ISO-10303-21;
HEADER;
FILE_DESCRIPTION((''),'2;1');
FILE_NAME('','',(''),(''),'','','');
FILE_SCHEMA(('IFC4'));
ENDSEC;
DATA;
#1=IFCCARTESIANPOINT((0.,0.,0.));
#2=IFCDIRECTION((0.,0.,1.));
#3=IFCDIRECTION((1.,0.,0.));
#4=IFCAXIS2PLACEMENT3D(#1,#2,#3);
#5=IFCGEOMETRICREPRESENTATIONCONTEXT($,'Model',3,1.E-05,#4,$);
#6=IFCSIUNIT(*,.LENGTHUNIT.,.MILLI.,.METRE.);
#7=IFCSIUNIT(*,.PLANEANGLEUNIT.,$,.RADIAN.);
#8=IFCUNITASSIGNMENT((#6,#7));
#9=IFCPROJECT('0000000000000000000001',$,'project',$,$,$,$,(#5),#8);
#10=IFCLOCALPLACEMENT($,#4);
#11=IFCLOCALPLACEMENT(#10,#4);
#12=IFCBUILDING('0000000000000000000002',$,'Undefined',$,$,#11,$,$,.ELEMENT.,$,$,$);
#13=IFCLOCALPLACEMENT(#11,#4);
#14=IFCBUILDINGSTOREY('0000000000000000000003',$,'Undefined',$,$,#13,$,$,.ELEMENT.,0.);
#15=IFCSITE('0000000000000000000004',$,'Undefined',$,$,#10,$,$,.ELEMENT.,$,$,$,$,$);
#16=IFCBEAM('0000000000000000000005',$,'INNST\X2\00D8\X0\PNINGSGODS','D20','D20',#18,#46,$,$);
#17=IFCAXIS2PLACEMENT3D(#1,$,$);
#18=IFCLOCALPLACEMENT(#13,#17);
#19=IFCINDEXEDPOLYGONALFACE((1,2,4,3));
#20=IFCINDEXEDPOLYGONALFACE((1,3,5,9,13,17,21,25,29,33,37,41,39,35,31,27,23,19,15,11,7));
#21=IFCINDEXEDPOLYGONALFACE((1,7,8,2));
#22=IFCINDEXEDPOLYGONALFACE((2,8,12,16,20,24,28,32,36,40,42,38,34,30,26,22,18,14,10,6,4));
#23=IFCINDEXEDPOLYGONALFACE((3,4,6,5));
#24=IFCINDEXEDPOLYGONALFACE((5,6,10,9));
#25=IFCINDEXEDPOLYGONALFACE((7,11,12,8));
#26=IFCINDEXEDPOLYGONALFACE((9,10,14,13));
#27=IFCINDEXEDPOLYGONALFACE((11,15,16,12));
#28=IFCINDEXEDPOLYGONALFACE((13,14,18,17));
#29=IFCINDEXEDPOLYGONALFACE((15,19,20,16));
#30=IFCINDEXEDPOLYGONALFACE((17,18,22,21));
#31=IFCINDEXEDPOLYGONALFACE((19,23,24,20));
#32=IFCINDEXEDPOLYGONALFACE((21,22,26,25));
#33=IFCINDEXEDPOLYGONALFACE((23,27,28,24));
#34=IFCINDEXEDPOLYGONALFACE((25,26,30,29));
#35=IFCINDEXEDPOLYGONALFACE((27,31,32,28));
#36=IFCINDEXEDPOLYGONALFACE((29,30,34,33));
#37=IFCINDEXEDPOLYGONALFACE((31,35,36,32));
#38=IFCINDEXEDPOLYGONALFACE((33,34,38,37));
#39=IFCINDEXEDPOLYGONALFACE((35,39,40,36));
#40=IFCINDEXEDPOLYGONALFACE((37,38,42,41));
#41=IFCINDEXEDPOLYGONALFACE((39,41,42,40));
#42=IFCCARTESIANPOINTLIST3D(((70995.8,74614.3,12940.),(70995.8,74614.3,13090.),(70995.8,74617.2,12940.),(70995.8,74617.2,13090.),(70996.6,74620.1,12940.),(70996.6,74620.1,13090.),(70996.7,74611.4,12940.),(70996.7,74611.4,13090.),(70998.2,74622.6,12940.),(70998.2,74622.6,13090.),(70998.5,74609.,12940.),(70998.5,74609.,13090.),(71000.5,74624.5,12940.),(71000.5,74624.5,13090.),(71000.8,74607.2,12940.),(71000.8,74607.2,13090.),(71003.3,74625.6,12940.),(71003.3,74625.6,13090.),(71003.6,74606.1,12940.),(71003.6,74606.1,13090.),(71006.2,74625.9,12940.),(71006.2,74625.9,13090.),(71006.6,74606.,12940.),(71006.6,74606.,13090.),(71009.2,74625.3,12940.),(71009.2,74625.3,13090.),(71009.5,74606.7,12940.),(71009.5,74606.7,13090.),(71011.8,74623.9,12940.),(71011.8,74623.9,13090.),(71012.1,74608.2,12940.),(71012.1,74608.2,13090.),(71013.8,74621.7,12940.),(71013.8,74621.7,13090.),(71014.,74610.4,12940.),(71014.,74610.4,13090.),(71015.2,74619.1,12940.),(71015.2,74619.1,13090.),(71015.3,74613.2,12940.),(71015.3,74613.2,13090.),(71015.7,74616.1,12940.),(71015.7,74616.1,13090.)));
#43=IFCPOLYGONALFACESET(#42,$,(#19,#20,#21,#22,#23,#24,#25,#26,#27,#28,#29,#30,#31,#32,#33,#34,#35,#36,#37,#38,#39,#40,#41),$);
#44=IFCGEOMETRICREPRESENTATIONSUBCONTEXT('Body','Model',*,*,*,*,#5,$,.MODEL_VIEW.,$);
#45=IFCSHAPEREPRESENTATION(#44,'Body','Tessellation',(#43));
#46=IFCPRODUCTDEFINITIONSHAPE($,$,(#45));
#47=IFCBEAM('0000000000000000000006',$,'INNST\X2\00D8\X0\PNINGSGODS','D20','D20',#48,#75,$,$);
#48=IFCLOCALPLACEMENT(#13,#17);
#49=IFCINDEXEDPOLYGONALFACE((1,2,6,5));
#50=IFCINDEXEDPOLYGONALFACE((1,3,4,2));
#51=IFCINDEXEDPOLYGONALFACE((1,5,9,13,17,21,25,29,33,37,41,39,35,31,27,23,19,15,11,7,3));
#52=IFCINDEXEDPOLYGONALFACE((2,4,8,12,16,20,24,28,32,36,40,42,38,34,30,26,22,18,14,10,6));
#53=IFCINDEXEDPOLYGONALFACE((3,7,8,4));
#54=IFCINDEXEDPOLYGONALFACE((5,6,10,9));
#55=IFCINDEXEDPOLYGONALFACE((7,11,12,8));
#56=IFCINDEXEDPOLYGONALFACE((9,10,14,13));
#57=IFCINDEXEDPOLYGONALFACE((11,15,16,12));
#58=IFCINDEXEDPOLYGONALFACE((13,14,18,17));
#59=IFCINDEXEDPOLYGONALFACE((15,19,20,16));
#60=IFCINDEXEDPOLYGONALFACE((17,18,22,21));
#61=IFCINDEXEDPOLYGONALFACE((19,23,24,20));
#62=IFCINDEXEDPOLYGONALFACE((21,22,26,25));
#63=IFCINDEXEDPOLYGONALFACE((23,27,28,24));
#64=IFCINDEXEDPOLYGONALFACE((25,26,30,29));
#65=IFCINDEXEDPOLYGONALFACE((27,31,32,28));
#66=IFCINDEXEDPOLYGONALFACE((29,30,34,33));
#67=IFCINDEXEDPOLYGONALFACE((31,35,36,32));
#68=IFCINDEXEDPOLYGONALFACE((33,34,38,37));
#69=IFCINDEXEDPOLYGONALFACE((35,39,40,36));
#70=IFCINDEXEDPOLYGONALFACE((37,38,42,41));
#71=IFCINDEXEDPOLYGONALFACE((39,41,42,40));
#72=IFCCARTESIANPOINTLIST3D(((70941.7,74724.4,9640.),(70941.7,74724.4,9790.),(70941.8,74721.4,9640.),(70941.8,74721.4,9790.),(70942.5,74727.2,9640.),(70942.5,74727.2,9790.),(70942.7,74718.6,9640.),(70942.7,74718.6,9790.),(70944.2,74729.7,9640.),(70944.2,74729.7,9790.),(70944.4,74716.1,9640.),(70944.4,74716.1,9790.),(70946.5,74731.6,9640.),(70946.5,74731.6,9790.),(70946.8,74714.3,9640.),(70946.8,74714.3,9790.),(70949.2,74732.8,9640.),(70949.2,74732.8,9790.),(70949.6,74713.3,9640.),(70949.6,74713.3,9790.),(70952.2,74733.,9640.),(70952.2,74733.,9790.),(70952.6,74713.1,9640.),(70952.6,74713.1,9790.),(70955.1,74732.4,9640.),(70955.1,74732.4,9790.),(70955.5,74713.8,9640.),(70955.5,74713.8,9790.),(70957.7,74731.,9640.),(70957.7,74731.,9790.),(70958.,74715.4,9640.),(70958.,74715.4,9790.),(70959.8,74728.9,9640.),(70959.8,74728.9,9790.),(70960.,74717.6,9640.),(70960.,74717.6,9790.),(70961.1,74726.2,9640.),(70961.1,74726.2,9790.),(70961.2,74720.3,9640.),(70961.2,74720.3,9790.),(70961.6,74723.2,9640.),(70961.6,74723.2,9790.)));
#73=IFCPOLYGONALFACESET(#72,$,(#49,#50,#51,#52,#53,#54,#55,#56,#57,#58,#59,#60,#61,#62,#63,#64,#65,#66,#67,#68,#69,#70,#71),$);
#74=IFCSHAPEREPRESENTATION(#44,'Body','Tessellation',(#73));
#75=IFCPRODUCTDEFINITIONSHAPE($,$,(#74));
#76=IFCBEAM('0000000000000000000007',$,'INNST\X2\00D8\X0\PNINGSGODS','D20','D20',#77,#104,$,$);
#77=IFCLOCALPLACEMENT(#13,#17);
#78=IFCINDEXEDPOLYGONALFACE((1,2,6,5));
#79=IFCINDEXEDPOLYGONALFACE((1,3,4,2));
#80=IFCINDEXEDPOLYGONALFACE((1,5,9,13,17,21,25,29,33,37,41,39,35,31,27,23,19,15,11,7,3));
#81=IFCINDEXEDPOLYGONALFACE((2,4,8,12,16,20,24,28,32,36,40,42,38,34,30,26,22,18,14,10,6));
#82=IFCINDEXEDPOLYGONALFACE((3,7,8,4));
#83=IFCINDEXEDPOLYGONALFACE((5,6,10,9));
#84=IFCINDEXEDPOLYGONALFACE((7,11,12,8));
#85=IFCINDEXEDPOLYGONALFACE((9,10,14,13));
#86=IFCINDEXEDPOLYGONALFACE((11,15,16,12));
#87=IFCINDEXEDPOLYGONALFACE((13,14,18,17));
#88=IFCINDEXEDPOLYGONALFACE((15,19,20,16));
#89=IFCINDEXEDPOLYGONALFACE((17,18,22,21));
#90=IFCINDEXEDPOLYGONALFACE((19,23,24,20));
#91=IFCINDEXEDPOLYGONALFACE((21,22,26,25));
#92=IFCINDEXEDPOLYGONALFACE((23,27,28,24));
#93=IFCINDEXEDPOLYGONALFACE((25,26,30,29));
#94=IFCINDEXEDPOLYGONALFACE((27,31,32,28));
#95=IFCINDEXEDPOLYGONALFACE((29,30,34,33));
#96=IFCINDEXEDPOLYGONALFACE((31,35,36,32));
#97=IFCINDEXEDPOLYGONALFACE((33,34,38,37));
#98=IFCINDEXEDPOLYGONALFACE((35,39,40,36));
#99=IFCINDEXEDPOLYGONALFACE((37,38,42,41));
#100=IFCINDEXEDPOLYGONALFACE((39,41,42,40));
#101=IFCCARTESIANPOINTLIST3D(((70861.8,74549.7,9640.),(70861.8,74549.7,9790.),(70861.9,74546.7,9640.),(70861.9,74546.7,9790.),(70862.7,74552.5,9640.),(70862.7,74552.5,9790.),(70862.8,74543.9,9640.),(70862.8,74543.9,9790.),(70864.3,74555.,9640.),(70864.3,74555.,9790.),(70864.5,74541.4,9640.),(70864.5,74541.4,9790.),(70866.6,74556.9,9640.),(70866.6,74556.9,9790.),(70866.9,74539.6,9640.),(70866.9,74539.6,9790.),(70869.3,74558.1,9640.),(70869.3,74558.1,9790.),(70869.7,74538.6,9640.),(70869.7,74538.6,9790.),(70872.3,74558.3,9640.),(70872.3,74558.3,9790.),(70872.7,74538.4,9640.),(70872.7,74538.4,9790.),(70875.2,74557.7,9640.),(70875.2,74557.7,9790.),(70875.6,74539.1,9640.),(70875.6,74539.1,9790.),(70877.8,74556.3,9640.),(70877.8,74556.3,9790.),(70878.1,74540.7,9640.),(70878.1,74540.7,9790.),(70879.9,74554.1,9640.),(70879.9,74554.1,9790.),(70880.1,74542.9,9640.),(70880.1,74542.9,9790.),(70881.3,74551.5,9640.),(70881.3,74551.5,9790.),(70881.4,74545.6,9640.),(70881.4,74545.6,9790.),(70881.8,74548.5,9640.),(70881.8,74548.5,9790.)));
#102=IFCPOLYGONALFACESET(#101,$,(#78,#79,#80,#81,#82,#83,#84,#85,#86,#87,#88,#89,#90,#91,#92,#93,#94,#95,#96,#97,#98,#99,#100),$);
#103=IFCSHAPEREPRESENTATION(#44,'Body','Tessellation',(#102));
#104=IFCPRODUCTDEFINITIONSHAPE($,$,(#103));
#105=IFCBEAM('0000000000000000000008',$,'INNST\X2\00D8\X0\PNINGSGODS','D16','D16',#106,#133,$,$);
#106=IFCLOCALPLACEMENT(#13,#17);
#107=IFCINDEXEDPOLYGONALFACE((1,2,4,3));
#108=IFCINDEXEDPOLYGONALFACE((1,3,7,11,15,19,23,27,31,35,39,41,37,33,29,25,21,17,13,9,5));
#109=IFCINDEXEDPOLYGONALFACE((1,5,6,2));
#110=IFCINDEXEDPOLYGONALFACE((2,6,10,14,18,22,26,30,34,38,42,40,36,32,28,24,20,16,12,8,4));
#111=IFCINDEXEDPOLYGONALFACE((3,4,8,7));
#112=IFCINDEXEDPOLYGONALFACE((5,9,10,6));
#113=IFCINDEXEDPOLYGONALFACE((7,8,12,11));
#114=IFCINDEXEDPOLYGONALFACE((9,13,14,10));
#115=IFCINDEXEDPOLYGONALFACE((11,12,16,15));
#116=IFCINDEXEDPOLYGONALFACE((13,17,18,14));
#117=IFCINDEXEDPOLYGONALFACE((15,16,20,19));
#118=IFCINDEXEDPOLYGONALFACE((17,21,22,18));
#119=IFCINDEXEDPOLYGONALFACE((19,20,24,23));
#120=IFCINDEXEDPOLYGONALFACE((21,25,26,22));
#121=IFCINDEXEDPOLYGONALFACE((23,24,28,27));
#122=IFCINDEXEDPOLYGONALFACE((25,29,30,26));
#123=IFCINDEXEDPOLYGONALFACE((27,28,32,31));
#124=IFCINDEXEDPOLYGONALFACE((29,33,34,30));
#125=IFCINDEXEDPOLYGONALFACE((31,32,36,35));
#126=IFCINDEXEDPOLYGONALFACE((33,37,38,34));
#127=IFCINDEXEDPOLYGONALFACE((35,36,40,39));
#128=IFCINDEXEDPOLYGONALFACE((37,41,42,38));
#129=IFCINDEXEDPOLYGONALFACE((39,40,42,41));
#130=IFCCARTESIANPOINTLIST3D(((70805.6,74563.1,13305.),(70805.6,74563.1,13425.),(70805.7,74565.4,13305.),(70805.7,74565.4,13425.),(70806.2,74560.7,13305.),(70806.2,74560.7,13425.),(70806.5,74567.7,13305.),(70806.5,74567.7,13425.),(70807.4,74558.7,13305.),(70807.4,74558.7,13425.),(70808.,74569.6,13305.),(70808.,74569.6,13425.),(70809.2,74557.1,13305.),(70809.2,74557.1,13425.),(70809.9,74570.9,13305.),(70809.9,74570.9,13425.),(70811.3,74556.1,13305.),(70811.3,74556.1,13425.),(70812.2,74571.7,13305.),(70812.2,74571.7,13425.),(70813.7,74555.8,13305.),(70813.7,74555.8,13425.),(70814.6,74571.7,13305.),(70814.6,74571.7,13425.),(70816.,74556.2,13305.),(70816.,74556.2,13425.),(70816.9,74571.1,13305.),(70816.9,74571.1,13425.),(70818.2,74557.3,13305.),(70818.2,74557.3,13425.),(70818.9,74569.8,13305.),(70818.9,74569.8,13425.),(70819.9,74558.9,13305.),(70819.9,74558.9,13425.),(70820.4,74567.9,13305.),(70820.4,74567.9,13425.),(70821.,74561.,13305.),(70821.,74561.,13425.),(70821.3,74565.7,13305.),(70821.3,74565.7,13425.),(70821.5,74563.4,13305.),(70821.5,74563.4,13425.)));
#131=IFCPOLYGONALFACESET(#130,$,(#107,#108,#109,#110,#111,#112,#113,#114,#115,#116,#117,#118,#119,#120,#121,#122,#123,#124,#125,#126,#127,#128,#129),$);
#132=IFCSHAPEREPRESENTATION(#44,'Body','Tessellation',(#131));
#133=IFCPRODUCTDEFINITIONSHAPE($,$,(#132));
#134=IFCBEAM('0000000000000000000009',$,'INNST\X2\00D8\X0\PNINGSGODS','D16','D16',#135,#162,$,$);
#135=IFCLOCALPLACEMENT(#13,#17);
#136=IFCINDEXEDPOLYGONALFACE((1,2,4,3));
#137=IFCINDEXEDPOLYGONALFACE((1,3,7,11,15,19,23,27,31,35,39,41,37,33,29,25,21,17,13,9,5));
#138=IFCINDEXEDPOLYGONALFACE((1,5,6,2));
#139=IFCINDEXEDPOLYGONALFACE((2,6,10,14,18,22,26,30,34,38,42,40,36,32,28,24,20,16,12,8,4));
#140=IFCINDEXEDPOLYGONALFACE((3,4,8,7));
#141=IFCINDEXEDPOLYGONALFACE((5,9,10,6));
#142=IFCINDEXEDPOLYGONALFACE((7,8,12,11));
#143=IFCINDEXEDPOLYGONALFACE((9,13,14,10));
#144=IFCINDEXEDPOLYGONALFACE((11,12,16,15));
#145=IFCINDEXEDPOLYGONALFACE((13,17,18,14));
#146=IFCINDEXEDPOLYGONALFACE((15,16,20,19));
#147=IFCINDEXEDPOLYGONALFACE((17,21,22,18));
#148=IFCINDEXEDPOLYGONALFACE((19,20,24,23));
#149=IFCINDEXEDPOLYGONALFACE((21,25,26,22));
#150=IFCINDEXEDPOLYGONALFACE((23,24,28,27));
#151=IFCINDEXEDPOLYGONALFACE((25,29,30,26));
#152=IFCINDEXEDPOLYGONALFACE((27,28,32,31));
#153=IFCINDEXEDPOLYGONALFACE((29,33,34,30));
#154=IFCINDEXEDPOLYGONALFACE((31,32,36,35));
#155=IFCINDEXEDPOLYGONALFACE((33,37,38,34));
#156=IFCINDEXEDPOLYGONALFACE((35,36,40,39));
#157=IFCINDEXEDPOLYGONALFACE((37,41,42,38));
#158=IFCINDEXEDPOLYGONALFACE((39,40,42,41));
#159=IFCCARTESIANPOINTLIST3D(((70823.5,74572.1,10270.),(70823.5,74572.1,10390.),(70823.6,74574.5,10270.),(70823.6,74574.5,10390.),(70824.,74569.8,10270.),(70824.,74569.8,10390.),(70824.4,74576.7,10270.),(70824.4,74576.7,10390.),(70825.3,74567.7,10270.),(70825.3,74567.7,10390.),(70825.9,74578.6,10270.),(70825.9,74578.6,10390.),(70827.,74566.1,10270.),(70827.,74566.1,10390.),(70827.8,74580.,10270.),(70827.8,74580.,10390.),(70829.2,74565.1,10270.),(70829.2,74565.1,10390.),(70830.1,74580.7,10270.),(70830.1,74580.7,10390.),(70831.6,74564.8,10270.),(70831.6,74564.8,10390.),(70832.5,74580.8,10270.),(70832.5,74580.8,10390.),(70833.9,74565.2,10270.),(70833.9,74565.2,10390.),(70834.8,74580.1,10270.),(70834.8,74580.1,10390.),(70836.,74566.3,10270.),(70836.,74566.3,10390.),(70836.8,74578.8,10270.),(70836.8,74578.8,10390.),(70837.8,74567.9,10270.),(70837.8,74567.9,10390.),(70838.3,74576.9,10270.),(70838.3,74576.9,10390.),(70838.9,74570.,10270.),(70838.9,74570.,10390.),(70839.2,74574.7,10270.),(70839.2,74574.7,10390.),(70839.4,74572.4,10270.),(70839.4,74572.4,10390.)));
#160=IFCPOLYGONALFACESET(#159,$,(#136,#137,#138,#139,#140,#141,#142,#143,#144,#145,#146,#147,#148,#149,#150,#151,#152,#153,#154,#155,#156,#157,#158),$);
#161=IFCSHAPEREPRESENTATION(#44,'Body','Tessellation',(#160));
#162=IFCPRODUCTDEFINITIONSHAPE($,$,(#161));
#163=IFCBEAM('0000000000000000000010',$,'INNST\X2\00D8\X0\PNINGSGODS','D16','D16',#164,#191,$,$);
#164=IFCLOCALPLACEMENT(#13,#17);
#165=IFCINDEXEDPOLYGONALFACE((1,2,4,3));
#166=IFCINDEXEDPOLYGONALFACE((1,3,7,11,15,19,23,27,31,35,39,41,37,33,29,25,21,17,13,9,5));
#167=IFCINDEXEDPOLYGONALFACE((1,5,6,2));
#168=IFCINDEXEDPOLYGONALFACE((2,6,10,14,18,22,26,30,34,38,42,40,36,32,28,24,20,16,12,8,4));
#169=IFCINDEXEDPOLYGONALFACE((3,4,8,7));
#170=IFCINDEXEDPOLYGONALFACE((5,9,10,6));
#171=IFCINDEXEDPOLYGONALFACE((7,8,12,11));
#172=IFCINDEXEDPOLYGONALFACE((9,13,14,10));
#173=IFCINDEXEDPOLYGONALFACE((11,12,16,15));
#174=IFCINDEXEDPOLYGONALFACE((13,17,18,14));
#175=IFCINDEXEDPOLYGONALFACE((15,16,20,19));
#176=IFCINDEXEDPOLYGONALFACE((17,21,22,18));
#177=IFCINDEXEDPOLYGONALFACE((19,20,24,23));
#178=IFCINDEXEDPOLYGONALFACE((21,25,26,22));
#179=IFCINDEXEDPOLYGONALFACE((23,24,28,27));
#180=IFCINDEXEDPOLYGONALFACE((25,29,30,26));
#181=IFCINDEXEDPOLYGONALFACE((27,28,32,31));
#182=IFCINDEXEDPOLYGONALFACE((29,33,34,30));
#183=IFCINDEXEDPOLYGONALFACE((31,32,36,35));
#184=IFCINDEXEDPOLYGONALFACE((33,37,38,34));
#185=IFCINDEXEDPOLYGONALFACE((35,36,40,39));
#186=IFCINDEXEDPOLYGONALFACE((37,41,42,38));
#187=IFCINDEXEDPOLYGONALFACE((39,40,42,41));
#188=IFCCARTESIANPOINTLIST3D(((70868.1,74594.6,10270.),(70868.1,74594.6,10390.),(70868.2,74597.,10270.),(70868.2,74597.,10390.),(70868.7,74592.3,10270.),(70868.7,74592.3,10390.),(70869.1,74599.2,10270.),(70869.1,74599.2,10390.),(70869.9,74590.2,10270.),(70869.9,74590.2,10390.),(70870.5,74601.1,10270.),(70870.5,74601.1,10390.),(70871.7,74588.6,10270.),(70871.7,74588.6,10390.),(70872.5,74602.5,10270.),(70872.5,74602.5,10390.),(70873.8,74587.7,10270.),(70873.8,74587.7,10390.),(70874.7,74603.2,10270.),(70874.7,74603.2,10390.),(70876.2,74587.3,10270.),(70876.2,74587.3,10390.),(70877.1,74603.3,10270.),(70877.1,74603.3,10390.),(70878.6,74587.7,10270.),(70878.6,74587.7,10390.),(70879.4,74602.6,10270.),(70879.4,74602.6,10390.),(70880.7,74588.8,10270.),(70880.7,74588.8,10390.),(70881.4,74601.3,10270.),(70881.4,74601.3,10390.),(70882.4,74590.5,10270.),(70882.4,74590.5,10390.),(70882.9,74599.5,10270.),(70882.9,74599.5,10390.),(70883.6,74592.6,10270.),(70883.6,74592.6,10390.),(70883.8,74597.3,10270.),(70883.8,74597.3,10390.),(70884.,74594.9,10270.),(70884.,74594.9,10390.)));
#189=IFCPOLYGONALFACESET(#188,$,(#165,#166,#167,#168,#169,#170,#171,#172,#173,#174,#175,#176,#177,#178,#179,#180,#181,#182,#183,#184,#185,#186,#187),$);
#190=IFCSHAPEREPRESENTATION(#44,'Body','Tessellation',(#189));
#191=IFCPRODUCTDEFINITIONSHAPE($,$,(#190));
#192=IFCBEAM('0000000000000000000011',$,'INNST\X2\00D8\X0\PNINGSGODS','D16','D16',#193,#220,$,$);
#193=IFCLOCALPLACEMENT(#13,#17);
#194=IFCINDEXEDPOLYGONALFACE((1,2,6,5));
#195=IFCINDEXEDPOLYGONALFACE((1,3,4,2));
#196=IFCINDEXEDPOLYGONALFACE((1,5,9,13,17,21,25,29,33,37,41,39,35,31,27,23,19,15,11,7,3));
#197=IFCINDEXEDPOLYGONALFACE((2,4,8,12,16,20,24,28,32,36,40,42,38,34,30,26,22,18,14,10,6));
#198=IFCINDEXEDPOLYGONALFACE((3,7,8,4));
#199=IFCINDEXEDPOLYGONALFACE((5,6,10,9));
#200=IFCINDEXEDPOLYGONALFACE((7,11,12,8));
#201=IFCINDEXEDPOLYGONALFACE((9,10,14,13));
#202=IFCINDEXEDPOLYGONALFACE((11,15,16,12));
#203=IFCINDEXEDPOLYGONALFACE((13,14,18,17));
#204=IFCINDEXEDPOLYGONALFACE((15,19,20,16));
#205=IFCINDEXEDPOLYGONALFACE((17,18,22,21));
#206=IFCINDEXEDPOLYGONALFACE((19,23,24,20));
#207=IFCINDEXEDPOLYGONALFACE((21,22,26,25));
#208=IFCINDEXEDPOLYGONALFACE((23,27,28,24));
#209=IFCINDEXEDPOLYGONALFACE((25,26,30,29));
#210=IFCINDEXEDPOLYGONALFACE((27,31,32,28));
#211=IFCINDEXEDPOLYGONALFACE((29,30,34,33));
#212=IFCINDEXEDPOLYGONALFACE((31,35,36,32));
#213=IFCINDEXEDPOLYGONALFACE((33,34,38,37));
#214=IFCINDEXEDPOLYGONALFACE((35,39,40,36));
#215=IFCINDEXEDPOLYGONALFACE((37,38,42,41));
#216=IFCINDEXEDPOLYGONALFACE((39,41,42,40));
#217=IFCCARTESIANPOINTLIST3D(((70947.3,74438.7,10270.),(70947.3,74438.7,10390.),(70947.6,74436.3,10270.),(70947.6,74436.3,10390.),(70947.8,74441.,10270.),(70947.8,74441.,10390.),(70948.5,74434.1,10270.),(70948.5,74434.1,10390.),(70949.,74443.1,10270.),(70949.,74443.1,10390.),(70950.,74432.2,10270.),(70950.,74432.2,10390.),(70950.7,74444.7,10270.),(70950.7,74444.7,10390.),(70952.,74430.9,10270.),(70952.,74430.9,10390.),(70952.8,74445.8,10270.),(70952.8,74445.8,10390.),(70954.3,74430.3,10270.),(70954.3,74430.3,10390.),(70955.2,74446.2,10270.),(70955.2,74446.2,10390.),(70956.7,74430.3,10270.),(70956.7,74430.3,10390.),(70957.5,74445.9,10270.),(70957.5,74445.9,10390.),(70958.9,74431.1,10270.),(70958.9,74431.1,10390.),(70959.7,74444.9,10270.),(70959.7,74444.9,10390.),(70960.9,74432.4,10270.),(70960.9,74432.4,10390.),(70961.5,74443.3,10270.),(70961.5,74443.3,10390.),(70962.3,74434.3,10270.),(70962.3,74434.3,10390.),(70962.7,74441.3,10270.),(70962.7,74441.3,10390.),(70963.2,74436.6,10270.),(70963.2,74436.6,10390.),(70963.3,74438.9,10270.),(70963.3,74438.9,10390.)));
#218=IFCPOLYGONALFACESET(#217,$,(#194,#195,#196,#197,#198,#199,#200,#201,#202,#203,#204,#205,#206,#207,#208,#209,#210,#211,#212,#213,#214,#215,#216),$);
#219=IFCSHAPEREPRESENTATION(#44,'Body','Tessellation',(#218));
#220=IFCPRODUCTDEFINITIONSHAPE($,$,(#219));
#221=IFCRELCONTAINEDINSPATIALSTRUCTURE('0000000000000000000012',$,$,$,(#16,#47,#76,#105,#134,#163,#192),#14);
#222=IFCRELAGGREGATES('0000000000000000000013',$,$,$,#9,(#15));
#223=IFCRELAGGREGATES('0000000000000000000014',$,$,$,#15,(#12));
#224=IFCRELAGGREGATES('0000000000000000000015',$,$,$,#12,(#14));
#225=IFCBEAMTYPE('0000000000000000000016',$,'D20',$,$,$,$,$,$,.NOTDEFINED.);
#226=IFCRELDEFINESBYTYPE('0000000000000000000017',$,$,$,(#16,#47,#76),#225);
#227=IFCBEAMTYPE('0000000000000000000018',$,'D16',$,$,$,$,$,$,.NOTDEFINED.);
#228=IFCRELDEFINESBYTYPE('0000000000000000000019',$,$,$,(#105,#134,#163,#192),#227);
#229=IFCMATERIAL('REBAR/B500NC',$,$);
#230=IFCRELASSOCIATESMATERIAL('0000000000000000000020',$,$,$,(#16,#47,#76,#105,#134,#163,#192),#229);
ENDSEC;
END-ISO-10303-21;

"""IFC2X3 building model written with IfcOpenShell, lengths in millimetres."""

from ifc_helpers import new_model, si_unit, frame, origin_with_axes, origin_2d_with_axis, place, context, subcontext, project, spatial, circle, extrude, material, type_object, element, save


model = new_model("IFC2X3")

# Units and contexts
model_context = context("Model", 3, precision=1e-05, world=origin_with_axes())
body_context = subcontext(model_context, "Body", "Model", "MODEL_VIEW")
ifc_project = project(units=[si_unit("LENGTHUNIT", "METRE", prefix="MILLI"), si_unit("PLANEANGLEUNIT", "RADIAN")], contexts=[model_context])

# Site, building, storey
site_placement = place(None, origin_with_axes())
site = spatial("IfcSite", under=ifc_project, at=site_placement, Name="Undefined", CompositionType="ELEMENT")
building_placement = place(site_placement, origin_with_axes())
building = spatial("IfcBuilding", under=site, at=building_placement, Name="Undefined", CompositionType="ELEMENT")
storey_placement = place(building_placement, origin_with_axes())
storey = spatial("IfcBuildingStorey", under=building, at=storey_placement, Name="Undefined", CompositionType="ELEMENT", Elevation=0.0)

# Beams
ifc_material_1 = material(Name="REBAR/B500NC")
beam_type_1 = type_object("IfcBeamType", Name="D20", PredefinedType="NOTDEFINED")
for number, where, z_axis, x_axis, name in (
    (1, (71005.7, 74615.9, 13090.0), (0.450411, -0.892821, 0.0), (0.0, 0.0, -1.0), "INNSTØPNINGSGODS"),
    (2, (70951.6, 74723.1, 9790.0), (0.450411, -0.892821, 0.0), (0.0, 0.0, -1.0), "INNSTØPNINGSGODS"),
    (3, (70871.8, 74548.4, 9790.0), (0.450411, -0.892821, 0.0), (0.0, 0.0, -1.0), "INNSTØPNINGSGODS"),
):
    element("IfcBeam", number, at=place(storey_placement, frame(where, z_axis=z_axis, x_axis=x_axis)), inside=storey, type_object=beam_type_1, material=ifc_material_1, Name=name, Description="D20", ObjectType="D20", context=body_context, shape_type="SweptSolid", body=[
        extrude(circle(Radius=10.0, at=origin_2d_with_axis()), frame((150.0, 0.0, 0.0), z_axis=(-1.0, 0.0, 0.0), x_axis=(0.0, -1.0, 0.0)), (0.0, 0.0, 1.0), 150.0),
    ])
beam_type_2 = type_object("IfcBeamType", Name="D16", PredefinedType="NOTDEFINED")
for number, where, z_axis, x_axis, name in (
    (4, (70813.5, 74563.8, 13425.0), (-0.892821, -0.450411, 0.0), (0.0, 0.0, -1.0), "INNSTØPNINGSGODS"),
    (5, (70831.4, 74572.8, 10390.0), (-0.892821, -0.450411, 0.0), (0.0, 0.0, -1.0), "INNSTØPNINGSGODS"),
    (6, (70876.1, 74595.3, 10390.0), (-0.892821, -0.450411, 0.0), (0.0, 0.0, -1.0), "INNSTØPNINGSGODS"),
    (7, (70955.3, 74438.2, 10390.0), (0.892821, 0.450411, 0.0), (0.0, 0.0, -1.0), "INNSTØPNINGSGODS"),
):
    element("IfcBeam", number, at=place(storey_placement, frame(where, z_axis=z_axis, x_axis=x_axis)), inside=storey, type_object=beam_type_2, material=ifc_material_1, Name=name, Description="D16", ObjectType="D16", context=body_context, shape_type="SweptSolid", body=[
        extrude(circle(Radius=8.0, at=origin_2d_with_axis()), frame((120.0, 0.0, 0.0), z_axis=(-1.0, 0.0, 0.0), x_axis=(0.0, -1.0, 0.0)), (0.0, 0.0, 1.0), 120.0),
    ])

save(model, "model.ifc")
